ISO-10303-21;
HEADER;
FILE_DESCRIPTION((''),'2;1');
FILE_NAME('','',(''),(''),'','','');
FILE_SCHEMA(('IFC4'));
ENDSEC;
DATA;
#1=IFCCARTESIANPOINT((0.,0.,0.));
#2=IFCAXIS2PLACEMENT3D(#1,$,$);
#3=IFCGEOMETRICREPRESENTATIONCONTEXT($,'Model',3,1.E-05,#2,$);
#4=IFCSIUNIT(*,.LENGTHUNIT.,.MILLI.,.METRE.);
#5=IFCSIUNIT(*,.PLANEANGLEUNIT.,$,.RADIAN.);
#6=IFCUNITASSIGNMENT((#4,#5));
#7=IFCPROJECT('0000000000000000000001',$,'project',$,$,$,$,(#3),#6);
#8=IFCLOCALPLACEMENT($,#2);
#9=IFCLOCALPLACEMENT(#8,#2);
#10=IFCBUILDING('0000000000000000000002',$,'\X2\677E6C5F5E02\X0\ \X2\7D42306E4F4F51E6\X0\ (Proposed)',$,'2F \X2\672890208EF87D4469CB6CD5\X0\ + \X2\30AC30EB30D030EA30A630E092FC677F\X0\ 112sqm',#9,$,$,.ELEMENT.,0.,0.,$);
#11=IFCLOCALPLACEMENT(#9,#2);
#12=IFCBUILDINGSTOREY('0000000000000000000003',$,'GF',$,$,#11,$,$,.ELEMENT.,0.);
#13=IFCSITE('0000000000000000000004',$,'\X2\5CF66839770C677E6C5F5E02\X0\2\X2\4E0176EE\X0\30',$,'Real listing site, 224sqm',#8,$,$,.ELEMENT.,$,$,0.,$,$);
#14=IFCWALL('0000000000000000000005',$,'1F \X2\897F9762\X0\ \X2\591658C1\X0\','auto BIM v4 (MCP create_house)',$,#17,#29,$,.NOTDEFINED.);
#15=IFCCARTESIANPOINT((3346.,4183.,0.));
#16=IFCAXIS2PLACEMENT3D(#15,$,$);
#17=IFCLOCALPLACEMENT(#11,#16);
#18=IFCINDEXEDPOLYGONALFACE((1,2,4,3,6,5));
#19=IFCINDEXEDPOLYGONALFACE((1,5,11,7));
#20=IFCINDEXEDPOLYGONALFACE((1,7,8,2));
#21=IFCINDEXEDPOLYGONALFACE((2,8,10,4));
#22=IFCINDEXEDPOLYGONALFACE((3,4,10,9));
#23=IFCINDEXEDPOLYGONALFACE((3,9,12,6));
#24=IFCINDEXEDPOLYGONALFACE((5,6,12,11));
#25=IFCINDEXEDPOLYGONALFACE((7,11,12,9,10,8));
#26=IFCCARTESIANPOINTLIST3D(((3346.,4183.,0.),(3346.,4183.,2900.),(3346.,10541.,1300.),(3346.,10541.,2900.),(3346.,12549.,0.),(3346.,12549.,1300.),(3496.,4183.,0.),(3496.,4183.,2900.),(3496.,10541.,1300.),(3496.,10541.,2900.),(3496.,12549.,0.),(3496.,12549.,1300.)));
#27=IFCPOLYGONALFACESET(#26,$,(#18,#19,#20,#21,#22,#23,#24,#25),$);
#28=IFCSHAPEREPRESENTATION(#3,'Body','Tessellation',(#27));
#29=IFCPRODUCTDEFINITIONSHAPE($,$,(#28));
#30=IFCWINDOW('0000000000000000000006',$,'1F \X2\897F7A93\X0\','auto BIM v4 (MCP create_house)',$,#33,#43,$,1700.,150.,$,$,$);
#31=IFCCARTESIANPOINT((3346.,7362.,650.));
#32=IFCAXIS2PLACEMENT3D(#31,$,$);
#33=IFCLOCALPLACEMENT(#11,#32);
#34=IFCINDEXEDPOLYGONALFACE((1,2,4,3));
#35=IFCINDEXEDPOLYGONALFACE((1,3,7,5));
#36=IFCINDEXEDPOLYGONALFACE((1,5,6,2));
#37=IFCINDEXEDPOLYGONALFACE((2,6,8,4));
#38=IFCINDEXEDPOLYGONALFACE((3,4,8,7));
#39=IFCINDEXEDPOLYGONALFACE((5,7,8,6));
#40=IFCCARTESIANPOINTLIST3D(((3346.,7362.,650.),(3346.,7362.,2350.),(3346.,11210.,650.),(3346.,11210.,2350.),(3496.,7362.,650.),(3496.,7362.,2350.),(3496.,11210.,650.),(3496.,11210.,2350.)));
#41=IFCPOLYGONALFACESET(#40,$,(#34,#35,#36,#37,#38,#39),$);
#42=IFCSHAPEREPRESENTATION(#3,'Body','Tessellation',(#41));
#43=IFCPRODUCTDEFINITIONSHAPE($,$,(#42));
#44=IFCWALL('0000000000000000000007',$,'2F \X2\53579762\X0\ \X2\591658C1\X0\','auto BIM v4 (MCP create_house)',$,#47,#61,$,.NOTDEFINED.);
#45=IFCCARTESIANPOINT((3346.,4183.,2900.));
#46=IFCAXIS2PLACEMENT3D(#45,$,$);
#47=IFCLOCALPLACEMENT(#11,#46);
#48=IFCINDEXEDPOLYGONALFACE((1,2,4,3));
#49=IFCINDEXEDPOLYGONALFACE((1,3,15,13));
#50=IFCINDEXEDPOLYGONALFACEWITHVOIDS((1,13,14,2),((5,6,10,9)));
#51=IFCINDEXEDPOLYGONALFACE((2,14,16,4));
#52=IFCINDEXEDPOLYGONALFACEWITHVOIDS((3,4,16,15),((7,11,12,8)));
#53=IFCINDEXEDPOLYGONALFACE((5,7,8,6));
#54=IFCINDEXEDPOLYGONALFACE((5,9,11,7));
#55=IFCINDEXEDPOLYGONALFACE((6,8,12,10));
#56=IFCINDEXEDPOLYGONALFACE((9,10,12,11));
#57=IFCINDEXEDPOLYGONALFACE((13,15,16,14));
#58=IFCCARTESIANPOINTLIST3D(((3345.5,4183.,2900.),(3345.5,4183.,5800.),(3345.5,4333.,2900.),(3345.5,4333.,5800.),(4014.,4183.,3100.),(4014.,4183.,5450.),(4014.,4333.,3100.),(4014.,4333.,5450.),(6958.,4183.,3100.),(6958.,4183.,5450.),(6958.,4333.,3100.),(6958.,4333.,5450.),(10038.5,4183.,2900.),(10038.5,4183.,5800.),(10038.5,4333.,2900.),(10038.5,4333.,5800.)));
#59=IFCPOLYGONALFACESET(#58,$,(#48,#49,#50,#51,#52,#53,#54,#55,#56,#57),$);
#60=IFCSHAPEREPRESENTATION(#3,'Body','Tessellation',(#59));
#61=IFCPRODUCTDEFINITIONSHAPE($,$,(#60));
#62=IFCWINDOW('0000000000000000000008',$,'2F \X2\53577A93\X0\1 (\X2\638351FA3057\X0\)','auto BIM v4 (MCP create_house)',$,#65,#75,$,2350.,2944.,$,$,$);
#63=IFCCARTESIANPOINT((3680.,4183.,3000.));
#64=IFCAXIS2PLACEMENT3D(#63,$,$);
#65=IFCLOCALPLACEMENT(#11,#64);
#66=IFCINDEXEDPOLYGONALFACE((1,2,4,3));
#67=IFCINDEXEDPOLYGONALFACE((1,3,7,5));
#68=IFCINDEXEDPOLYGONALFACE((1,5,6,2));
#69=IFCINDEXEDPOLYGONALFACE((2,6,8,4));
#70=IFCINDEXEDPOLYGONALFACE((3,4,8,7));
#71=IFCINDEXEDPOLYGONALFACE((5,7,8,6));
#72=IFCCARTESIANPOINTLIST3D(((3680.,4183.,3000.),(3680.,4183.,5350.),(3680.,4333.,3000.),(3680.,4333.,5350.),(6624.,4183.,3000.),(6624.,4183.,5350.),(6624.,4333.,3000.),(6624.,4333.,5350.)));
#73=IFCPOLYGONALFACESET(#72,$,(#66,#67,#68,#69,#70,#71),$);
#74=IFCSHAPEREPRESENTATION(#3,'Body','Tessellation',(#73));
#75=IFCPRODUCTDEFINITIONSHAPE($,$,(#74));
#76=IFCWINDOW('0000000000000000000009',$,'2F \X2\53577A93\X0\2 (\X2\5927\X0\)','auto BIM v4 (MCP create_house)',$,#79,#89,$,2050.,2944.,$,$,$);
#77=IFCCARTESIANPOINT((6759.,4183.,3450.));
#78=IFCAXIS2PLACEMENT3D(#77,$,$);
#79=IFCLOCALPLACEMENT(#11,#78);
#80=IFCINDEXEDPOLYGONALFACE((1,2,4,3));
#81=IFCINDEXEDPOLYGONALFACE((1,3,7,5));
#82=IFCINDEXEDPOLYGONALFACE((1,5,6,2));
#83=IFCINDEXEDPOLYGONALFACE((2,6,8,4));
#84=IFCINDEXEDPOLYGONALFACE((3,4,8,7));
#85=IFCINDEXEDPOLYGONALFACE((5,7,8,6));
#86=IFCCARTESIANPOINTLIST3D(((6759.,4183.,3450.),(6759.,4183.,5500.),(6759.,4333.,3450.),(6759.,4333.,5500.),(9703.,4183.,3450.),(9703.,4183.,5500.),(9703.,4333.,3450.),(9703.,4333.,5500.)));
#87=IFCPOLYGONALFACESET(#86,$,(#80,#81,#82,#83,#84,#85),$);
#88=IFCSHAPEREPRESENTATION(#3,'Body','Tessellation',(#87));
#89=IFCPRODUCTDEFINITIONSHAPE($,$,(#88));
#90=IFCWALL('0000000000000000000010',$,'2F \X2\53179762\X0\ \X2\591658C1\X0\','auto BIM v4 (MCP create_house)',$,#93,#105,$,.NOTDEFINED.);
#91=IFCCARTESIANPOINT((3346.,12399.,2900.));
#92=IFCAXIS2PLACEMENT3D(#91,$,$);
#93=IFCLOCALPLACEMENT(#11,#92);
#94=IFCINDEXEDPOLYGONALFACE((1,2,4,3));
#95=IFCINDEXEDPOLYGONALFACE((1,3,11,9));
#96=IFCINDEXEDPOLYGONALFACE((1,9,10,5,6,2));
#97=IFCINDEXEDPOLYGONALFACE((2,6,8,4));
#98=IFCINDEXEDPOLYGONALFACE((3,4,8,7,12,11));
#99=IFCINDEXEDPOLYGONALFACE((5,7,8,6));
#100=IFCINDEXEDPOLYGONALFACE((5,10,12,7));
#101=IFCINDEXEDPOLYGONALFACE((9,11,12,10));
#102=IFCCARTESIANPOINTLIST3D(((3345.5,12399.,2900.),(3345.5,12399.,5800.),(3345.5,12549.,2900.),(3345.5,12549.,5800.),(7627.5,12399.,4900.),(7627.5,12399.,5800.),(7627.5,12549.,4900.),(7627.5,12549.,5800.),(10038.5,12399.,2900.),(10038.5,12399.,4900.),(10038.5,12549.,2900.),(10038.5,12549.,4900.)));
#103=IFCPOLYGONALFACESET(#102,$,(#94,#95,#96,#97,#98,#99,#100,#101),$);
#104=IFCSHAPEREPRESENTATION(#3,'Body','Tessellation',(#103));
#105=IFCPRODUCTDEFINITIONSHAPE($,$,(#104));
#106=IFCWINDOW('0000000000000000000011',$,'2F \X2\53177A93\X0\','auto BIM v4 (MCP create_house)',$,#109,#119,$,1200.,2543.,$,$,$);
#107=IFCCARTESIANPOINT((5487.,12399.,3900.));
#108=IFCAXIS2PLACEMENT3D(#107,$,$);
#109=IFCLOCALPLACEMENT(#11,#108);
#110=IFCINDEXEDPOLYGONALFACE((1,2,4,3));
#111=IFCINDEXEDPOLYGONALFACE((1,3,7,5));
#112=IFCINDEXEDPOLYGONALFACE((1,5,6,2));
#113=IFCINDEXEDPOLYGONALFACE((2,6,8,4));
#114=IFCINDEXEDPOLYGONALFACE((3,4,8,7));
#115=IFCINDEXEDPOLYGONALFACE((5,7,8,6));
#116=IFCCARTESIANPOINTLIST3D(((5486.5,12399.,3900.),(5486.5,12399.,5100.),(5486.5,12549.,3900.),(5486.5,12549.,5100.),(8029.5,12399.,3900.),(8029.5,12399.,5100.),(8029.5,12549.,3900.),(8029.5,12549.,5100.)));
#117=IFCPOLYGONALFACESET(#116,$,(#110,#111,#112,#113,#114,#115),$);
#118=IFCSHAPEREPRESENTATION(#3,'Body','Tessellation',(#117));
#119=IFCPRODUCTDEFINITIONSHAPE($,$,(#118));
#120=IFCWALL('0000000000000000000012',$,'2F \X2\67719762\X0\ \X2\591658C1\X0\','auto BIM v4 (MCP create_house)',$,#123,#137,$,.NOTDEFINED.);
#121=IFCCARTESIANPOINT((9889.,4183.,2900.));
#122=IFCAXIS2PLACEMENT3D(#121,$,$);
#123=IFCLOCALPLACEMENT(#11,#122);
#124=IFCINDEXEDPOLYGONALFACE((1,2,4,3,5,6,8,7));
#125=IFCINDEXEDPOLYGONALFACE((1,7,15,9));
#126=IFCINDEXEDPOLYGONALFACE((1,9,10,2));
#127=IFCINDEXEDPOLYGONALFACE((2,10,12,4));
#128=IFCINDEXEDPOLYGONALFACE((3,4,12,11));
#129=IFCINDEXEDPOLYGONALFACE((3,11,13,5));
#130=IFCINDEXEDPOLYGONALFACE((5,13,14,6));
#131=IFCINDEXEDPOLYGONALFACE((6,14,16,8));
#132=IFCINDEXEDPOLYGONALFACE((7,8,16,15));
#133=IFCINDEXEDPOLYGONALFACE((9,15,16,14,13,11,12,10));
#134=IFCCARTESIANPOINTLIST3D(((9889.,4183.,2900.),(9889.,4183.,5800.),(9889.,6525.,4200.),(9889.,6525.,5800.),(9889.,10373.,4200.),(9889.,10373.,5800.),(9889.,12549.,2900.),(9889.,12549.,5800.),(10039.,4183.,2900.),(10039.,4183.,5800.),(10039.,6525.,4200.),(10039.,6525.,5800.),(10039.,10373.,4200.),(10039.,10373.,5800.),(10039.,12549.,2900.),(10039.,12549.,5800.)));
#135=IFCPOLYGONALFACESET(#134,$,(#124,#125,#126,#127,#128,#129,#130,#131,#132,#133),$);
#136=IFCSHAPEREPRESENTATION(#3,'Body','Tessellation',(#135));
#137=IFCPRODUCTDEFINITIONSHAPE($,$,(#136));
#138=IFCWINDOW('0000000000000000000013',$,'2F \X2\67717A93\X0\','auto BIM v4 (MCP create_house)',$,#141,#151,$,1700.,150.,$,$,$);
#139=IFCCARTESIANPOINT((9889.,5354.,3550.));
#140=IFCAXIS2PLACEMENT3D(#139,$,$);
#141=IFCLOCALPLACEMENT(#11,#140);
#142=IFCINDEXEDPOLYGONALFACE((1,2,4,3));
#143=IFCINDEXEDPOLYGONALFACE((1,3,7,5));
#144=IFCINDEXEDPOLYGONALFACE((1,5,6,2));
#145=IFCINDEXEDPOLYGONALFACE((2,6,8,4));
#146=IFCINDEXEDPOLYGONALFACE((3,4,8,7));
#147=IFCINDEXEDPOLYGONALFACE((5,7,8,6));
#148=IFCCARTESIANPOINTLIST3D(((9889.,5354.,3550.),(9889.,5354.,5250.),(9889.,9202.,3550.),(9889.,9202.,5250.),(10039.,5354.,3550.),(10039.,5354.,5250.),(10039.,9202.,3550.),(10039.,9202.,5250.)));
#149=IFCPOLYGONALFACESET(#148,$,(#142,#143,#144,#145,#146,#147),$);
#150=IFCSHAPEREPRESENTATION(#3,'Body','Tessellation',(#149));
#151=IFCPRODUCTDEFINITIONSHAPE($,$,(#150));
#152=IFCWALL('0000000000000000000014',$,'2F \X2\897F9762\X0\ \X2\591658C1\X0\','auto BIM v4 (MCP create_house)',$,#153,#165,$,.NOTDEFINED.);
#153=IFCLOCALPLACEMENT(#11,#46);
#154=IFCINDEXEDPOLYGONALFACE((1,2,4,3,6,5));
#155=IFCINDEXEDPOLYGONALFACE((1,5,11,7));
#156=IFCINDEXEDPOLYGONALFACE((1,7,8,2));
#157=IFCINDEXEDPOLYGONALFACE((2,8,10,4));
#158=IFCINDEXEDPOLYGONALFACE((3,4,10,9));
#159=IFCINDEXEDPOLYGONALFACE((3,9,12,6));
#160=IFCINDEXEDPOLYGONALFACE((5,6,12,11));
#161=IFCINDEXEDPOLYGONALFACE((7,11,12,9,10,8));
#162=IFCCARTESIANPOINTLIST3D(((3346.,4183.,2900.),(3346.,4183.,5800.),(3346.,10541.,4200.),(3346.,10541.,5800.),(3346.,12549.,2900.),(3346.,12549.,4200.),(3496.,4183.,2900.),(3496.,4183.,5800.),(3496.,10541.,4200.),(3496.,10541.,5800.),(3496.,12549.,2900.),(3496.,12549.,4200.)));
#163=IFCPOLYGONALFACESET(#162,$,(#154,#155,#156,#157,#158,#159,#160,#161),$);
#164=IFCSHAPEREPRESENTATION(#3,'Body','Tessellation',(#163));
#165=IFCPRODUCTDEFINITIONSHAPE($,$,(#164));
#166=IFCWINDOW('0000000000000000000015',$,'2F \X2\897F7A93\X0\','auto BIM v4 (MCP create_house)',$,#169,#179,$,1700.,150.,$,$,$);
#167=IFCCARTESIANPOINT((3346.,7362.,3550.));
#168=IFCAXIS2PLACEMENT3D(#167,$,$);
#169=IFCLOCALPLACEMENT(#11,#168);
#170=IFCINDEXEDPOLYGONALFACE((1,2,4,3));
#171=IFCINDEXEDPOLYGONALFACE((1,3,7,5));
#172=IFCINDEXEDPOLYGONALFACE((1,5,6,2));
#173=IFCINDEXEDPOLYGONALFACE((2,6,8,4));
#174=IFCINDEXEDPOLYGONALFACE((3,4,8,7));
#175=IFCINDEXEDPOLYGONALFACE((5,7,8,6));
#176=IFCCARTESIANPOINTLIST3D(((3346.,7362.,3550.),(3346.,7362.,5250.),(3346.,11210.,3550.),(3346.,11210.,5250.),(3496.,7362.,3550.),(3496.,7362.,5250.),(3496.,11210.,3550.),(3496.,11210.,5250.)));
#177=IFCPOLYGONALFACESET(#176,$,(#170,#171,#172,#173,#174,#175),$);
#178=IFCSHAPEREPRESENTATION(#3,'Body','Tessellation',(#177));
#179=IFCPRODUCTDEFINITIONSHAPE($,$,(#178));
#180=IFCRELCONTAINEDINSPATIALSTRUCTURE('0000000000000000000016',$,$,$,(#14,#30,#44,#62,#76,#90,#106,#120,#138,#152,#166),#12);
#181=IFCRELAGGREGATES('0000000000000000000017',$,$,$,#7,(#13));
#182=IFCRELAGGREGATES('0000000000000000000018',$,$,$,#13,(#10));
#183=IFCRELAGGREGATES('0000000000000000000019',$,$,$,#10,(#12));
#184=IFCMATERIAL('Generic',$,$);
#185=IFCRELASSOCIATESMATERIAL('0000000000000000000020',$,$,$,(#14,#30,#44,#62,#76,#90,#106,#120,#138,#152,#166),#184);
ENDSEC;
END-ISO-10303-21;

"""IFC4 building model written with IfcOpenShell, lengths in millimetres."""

from ifc_helpers import new_model, si_unit, frame, frame_2d, origin, place, context, project, spatial, rectangle, extrude, material, element, fill, save


model = new_model("IFC4")

# Units and contexts
model_context = context("Model", 3, precision=1e-05, world=origin())
ifc_project = project(units=[si_unit("LENGTHUNIT", "METRE", prefix="MILLI"), si_unit("PLANEANGLEUNIT", "RADIAN")], contexts=[model_context])

# Site, building, storey
site_placement = place(None, origin())
site = spatial("IfcSite", under=ifc_project, at=site_placement, Name="島根県松江市2丁目30", ObjectType="Real listing site, 224sqm", CompositionType="ELEMENT", RefElevation=0.0)
building_placement = place(site_placement, origin())
building = spatial("IfcBuilding", under=site, at=building_placement, Name="松江市 終の住処 (Proposed)", ObjectType="2F 木造軸組構法 + ガルバリウム鋼板 112sqm", CompositionType="ELEMENT", ElevationOfRefHeight=0.0, ElevationOfTerrain=0.0)
storey_placement = place(building_placement, origin())
storey = spatial("IfcBuildingStorey", under=building, at=storey_placement, Name="GF", CompositionType="ELEMENT", Elevation=0.0)

# Shared definitions
ifc_material = material(Name="Generic")

# Wall, opening, window
wall_1_placement = place(storey_placement, frame((3346.0, 4183.0, 0.0)))
wall_1 = element("IfcWall", 1, at=wall_1_placement, inside=storey, material=ifc_material, Name="1F 西面 外壁", Description="auto BIM v4 (MCP create_house)", PredefinedType="NOTDEFINED", context=model_context, shape_type="SweptSolid", body=[
    extrude(rectangle(XDim=150.0, YDim=8366.0, at=frame_2d((75.0, 4183.0))), frame((3346.0, 4183.0, 0.0)), (0.0, 0.0, 1.0), 2900.0),
])
opening_1_placement = place(storey_placement, frame((3346.0, 7362.0, 650.0)))
opening_1 = element("IfcOpeningElement", 2, at=opening_1_placement, cuts=wall_1, PredefinedType="NOTDEFINED", context=model_context, shape_type="SweptSolid", body=[
    extrude(rectangle(XDim=150.0, YDim=3848.0, at=frame_2d((75.0, 1924.0))), frame((3346.0, 7362.0, 650.0)), (0.0, 0.0, 1.0), 1700.0),
])
window_1_placement = place(storey_placement, frame((3346.0, 7362.0, 650.0)))
window_1 = element("IfcWindow", 3, at=window_1_placement, inside=storey, material=ifc_material, Name="1F 西窓", Description="auto BIM v4 (MCP create_house)", OverallHeight=1700.0, OverallWidth=150.0, context=model_context, shape_type="SweptSolid", body=[
    extrude(rectangle(XDim=150.0, YDim=3848.0, at=frame_2d((75.0, 1924.0))), frame((3346.0, 7362.0, 650.0)), (0.0, 0.0, 1.0), 1700.0),
])
fill(opening_1, window_1)

# Wall, openings, windows
wall_2_placement = place(storey_placement, frame((3346.0, 4183.0, 2900.0)))
wall_2 = element("IfcWall", 4, at=wall_2_placement, inside=storey, material=ifc_material, Name="2F 南面 外壁", Description="auto BIM v4 (MCP create_house)", PredefinedType="NOTDEFINED", context=model_context, shape_type="SweptSolid", body=[
    extrude(rectangle(XDim=6693.0, YDim=150.0, at=frame_2d((3346.0, 75.0))), frame((3346.0, 4183.0, 2900.0)), (0.0, 0.0, 1.0), 2900.0),
])
opening_2_placement = place(storey_placement, frame((3680.0, 4183.0, 3000.0)))
opening_2 = element("IfcOpeningElement", 5, at=opening_2_placement, cuts=wall_2, PredefinedType="NOTDEFINED", context=model_context, shape_type="SweptSolid", body=[
    extrude(rectangle(XDim=2944.0, YDim=150.0, at=frame_2d((1472.0, 75.0))), frame((3680.0, 4183.0, 3000.0)), (0.0, 0.0, 1.0), 2350.0),
])
opening_3_placement = place(storey_placement, frame((6759.0, 4183.0, 3450.0)))
opening_3 = element("IfcOpeningElement", 6, at=opening_3_placement, cuts=wall_2, PredefinedType="NOTDEFINED", context=model_context, shape_type="SweptSolid", body=[
    extrude(rectangle(XDim=2944.0, YDim=150.0, at=frame_2d((1472.0, 75.0))), frame((6759.0, 4183.0, 3450.0)), (0.0, 0.0, 1.0), 2050.0),
])
window_2_placement = place(storey_placement, frame((3680.0, 4183.0, 3000.0)))
window_2 = element("IfcWindow", 7, at=window_2_placement, inside=storey, material=ifc_material, Name="2F 南窓1 (掃出し)", Description="auto BIM v4 (MCP create_house)", OverallHeight=2350.0, OverallWidth=2944.0, context=model_context, shape_type="SweptSolid", body=[
    extrude(rectangle(XDim=2944.0, YDim=150.0, at=frame_2d((1472.0, 75.0))), frame((3680.0, 4183.0, 3000.0)), (0.0, 0.0, 1.0), 2350.0),
])
fill(opening_2, window_2)
window_3_placement = place(storey_placement, frame((6759.0, 4183.0, 3450.0)))
window_3 = element("IfcWindow", 8, at=window_3_placement, inside=storey, material=ifc_material, Name="2F 南窓2 (大)", Description="auto BIM v4 (MCP create_house)", OverallHeight=2050.0, OverallWidth=2944.0, context=model_context, shape_type="SweptSolid", body=[
    extrude(rectangle(XDim=2944.0, YDim=150.0, at=frame_2d((1472.0, 75.0))), frame((6759.0, 4183.0, 3450.0)), (0.0, 0.0, 1.0), 2050.0),
])
fill(opening_3, window_3)

# Walls, openings, windows
wall_3_placement = place(storey_placement, frame((3346.0, 12399.0, 2900.0)))
wall_3 = element("IfcWall", 9, at=wall_3_placement, inside=storey, material=ifc_material, Name="2F 北面 外壁", Description="auto BIM v4 (MCP create_house)", PredefinedType="NOTDEFINED", context=model_context, shape_type="SweptSolid", body=[
    extrude(rectangle(XDim=6693.0, YDim=150.0, at=frame_2d((3346.0, 75.0))), frame((3346.0, 12399.0, 2900.0)), (0.0, 0.0, 1.0), 2900.0),
])
opening_4_placement = place(storey_placement, frame((5487.0, 12399.0, 3900.0)))
opening_4 = element("IfcOpeningElement", 10, at=opening_4_placement, cuts=wall_3, PredefinedType="NOTDEFINED", context=model_context, shape_type="SweptSolid", body=[
    extrude(rectangle(XDim=2543.0, YDim=150.0, at=frame_2d((1271.0, 75.0))), frame((5487.0, 12399.0, 3900.0)), (0.0, 0.0, 1.0), 1200.0),
])
window_4_placement = place(storey_placement, frame((5487.0, 12399.0, 3900.0)))
window_4 = element("IfcWindow", 11, at=window_4_placement, inside=storey, material=ifc_material, Name="2F 北窓", Description="auto BIM v4 (MCP create_house)", OverallHeight=1200.0, OverallWidth=2543.0, context=model_context, shape_type="SweptSolid", body=[
    extrude(rectangle(XDim=2543.0, YDim=150.0, at=frame_2d((1271.0, 75.0))), frame((5487.0, 12399.0, 3900.0)), (0.0, 0.0, 1.0), 1200.0),
])
fill(opening_4, window_4)
wall_4_placement = place(storey_placement, frame((9889.0, 4183.0, 2900.0)))
wall_4 = element("IfcWall", 12, at=wall_4_placement, inside=storey, material=ifc_material, Name="2F 東面 外壁", Description="auto BIM v4 (MCP create_house)", PredefinedType="NOTDEFINED", context=model_context, shape_type="SweptSolid", body=[
    extrude(rectangle(XDim=150.0, YDim=8366.0, at=frame_2d((75.0, 4183.0))), frame((9889.0, 4183.0, 2900.0)), (0.0, 0.0, 1.0), 2900.0),
])
opening_5_placement = place(storey_placement, frame((9889.0, 5354.0, 3550.0)))
opening_5 = element("IfcOpeningElement", 13, at=opening_5_placement, cuts=wall_4, PredefinedType="NOTDEFINED", context=model_context, shape_type="SweptSolid", body=[
    extrude(rectangle(XDim=150.0, YDim=3848.0, at=frame_2d((75.0, 1924.0))), frame((9889.0, 5354.0, 3550.0)), (0.0, 0.0, 1.0), 1700.0),
])
window_5_placement = place(storey_placement, frame((9889.0, 5354.0, 3550.0)))
window_5 = element("IfcWindow", 14, at=window_5_placement, inside=storey, material=ifc_material, Name="2F 東窓", Description="auto BIM v4 (MCP create_house)", OverallHeight=1700.0, OverallWidth=150.0, context=model_context, shape_type="SweptSolid", body=[
    extrude(rectangle(XDim=150.0, YDim=3848.0, at=frame_2d((75.0, 1924.0))), frame((9889.0, 5354.0, 3550.0)), (0.0, 0.0, 1.0), 1700.0),
])
fill(opening_5, window_5)
wall_5_placement = place(storey_placement, frame((3346.0, 4183.0, 2900.0)))
wall_5 = element("IfcWall", 15, at=wall_5_placement, inside=storey, material=ifc_material, Name="2F 西面 外壁", Description="auto BIM v4 (MCP create_house)", PredefinedType="NOTDEFINED", context=model_context, shape_type="SweptSolid", body=[
    extrude(rectangle(XDim=150.0, YDim=8366.0, at=frame_2d((75.0, 4183.0))), frame((3346.0, 4183.0, 2900.0)), (0.0, 0.0, 1.0), 2900.0),
])
opening_6_placement = place(storey_placement, frame((3346.0, 7362.0, 3550.0)))
opening_6 = element("IfcOpeningElement", 16, at=opening_6_placement, cuts=wall_5, PredefinedType="NOTDEFINED", context=model_context, shape_type="SweptSolid", body=[
    extrude(rectangle(XDim=150.0, YDim=3848.0, at=frame_2d((75.0, 1924.0))), frame((3346.0, 7362.0, 3550.0)), (0.0, 0.0, 1.0), 1700.0),
])
window_6_placement = place(storey_placement, frame((3346.0, 7362.0, 3550.0)))
window_6 = element("IfcWindow", 17, at=window_6_placement, inside=storey, material=ifc_material, Name="2F 西窓", Description="auto BIM v4 (MCP create_house)", OverallHeight=1700.0, OverallWidth=150.0, context=model_context, shape_type="SweptSolid", body=[
    extrude(rectangle(XDim=150.0, YDim=3848.0, at=frame_2d((75.0, 1924.0))), frame((3346.0, 7362.0, 3550.0)), (0.0, 0.0, 1.0), 1700.0),
])
fill(opening_6, window_6)

save(model, "model.ifc")
